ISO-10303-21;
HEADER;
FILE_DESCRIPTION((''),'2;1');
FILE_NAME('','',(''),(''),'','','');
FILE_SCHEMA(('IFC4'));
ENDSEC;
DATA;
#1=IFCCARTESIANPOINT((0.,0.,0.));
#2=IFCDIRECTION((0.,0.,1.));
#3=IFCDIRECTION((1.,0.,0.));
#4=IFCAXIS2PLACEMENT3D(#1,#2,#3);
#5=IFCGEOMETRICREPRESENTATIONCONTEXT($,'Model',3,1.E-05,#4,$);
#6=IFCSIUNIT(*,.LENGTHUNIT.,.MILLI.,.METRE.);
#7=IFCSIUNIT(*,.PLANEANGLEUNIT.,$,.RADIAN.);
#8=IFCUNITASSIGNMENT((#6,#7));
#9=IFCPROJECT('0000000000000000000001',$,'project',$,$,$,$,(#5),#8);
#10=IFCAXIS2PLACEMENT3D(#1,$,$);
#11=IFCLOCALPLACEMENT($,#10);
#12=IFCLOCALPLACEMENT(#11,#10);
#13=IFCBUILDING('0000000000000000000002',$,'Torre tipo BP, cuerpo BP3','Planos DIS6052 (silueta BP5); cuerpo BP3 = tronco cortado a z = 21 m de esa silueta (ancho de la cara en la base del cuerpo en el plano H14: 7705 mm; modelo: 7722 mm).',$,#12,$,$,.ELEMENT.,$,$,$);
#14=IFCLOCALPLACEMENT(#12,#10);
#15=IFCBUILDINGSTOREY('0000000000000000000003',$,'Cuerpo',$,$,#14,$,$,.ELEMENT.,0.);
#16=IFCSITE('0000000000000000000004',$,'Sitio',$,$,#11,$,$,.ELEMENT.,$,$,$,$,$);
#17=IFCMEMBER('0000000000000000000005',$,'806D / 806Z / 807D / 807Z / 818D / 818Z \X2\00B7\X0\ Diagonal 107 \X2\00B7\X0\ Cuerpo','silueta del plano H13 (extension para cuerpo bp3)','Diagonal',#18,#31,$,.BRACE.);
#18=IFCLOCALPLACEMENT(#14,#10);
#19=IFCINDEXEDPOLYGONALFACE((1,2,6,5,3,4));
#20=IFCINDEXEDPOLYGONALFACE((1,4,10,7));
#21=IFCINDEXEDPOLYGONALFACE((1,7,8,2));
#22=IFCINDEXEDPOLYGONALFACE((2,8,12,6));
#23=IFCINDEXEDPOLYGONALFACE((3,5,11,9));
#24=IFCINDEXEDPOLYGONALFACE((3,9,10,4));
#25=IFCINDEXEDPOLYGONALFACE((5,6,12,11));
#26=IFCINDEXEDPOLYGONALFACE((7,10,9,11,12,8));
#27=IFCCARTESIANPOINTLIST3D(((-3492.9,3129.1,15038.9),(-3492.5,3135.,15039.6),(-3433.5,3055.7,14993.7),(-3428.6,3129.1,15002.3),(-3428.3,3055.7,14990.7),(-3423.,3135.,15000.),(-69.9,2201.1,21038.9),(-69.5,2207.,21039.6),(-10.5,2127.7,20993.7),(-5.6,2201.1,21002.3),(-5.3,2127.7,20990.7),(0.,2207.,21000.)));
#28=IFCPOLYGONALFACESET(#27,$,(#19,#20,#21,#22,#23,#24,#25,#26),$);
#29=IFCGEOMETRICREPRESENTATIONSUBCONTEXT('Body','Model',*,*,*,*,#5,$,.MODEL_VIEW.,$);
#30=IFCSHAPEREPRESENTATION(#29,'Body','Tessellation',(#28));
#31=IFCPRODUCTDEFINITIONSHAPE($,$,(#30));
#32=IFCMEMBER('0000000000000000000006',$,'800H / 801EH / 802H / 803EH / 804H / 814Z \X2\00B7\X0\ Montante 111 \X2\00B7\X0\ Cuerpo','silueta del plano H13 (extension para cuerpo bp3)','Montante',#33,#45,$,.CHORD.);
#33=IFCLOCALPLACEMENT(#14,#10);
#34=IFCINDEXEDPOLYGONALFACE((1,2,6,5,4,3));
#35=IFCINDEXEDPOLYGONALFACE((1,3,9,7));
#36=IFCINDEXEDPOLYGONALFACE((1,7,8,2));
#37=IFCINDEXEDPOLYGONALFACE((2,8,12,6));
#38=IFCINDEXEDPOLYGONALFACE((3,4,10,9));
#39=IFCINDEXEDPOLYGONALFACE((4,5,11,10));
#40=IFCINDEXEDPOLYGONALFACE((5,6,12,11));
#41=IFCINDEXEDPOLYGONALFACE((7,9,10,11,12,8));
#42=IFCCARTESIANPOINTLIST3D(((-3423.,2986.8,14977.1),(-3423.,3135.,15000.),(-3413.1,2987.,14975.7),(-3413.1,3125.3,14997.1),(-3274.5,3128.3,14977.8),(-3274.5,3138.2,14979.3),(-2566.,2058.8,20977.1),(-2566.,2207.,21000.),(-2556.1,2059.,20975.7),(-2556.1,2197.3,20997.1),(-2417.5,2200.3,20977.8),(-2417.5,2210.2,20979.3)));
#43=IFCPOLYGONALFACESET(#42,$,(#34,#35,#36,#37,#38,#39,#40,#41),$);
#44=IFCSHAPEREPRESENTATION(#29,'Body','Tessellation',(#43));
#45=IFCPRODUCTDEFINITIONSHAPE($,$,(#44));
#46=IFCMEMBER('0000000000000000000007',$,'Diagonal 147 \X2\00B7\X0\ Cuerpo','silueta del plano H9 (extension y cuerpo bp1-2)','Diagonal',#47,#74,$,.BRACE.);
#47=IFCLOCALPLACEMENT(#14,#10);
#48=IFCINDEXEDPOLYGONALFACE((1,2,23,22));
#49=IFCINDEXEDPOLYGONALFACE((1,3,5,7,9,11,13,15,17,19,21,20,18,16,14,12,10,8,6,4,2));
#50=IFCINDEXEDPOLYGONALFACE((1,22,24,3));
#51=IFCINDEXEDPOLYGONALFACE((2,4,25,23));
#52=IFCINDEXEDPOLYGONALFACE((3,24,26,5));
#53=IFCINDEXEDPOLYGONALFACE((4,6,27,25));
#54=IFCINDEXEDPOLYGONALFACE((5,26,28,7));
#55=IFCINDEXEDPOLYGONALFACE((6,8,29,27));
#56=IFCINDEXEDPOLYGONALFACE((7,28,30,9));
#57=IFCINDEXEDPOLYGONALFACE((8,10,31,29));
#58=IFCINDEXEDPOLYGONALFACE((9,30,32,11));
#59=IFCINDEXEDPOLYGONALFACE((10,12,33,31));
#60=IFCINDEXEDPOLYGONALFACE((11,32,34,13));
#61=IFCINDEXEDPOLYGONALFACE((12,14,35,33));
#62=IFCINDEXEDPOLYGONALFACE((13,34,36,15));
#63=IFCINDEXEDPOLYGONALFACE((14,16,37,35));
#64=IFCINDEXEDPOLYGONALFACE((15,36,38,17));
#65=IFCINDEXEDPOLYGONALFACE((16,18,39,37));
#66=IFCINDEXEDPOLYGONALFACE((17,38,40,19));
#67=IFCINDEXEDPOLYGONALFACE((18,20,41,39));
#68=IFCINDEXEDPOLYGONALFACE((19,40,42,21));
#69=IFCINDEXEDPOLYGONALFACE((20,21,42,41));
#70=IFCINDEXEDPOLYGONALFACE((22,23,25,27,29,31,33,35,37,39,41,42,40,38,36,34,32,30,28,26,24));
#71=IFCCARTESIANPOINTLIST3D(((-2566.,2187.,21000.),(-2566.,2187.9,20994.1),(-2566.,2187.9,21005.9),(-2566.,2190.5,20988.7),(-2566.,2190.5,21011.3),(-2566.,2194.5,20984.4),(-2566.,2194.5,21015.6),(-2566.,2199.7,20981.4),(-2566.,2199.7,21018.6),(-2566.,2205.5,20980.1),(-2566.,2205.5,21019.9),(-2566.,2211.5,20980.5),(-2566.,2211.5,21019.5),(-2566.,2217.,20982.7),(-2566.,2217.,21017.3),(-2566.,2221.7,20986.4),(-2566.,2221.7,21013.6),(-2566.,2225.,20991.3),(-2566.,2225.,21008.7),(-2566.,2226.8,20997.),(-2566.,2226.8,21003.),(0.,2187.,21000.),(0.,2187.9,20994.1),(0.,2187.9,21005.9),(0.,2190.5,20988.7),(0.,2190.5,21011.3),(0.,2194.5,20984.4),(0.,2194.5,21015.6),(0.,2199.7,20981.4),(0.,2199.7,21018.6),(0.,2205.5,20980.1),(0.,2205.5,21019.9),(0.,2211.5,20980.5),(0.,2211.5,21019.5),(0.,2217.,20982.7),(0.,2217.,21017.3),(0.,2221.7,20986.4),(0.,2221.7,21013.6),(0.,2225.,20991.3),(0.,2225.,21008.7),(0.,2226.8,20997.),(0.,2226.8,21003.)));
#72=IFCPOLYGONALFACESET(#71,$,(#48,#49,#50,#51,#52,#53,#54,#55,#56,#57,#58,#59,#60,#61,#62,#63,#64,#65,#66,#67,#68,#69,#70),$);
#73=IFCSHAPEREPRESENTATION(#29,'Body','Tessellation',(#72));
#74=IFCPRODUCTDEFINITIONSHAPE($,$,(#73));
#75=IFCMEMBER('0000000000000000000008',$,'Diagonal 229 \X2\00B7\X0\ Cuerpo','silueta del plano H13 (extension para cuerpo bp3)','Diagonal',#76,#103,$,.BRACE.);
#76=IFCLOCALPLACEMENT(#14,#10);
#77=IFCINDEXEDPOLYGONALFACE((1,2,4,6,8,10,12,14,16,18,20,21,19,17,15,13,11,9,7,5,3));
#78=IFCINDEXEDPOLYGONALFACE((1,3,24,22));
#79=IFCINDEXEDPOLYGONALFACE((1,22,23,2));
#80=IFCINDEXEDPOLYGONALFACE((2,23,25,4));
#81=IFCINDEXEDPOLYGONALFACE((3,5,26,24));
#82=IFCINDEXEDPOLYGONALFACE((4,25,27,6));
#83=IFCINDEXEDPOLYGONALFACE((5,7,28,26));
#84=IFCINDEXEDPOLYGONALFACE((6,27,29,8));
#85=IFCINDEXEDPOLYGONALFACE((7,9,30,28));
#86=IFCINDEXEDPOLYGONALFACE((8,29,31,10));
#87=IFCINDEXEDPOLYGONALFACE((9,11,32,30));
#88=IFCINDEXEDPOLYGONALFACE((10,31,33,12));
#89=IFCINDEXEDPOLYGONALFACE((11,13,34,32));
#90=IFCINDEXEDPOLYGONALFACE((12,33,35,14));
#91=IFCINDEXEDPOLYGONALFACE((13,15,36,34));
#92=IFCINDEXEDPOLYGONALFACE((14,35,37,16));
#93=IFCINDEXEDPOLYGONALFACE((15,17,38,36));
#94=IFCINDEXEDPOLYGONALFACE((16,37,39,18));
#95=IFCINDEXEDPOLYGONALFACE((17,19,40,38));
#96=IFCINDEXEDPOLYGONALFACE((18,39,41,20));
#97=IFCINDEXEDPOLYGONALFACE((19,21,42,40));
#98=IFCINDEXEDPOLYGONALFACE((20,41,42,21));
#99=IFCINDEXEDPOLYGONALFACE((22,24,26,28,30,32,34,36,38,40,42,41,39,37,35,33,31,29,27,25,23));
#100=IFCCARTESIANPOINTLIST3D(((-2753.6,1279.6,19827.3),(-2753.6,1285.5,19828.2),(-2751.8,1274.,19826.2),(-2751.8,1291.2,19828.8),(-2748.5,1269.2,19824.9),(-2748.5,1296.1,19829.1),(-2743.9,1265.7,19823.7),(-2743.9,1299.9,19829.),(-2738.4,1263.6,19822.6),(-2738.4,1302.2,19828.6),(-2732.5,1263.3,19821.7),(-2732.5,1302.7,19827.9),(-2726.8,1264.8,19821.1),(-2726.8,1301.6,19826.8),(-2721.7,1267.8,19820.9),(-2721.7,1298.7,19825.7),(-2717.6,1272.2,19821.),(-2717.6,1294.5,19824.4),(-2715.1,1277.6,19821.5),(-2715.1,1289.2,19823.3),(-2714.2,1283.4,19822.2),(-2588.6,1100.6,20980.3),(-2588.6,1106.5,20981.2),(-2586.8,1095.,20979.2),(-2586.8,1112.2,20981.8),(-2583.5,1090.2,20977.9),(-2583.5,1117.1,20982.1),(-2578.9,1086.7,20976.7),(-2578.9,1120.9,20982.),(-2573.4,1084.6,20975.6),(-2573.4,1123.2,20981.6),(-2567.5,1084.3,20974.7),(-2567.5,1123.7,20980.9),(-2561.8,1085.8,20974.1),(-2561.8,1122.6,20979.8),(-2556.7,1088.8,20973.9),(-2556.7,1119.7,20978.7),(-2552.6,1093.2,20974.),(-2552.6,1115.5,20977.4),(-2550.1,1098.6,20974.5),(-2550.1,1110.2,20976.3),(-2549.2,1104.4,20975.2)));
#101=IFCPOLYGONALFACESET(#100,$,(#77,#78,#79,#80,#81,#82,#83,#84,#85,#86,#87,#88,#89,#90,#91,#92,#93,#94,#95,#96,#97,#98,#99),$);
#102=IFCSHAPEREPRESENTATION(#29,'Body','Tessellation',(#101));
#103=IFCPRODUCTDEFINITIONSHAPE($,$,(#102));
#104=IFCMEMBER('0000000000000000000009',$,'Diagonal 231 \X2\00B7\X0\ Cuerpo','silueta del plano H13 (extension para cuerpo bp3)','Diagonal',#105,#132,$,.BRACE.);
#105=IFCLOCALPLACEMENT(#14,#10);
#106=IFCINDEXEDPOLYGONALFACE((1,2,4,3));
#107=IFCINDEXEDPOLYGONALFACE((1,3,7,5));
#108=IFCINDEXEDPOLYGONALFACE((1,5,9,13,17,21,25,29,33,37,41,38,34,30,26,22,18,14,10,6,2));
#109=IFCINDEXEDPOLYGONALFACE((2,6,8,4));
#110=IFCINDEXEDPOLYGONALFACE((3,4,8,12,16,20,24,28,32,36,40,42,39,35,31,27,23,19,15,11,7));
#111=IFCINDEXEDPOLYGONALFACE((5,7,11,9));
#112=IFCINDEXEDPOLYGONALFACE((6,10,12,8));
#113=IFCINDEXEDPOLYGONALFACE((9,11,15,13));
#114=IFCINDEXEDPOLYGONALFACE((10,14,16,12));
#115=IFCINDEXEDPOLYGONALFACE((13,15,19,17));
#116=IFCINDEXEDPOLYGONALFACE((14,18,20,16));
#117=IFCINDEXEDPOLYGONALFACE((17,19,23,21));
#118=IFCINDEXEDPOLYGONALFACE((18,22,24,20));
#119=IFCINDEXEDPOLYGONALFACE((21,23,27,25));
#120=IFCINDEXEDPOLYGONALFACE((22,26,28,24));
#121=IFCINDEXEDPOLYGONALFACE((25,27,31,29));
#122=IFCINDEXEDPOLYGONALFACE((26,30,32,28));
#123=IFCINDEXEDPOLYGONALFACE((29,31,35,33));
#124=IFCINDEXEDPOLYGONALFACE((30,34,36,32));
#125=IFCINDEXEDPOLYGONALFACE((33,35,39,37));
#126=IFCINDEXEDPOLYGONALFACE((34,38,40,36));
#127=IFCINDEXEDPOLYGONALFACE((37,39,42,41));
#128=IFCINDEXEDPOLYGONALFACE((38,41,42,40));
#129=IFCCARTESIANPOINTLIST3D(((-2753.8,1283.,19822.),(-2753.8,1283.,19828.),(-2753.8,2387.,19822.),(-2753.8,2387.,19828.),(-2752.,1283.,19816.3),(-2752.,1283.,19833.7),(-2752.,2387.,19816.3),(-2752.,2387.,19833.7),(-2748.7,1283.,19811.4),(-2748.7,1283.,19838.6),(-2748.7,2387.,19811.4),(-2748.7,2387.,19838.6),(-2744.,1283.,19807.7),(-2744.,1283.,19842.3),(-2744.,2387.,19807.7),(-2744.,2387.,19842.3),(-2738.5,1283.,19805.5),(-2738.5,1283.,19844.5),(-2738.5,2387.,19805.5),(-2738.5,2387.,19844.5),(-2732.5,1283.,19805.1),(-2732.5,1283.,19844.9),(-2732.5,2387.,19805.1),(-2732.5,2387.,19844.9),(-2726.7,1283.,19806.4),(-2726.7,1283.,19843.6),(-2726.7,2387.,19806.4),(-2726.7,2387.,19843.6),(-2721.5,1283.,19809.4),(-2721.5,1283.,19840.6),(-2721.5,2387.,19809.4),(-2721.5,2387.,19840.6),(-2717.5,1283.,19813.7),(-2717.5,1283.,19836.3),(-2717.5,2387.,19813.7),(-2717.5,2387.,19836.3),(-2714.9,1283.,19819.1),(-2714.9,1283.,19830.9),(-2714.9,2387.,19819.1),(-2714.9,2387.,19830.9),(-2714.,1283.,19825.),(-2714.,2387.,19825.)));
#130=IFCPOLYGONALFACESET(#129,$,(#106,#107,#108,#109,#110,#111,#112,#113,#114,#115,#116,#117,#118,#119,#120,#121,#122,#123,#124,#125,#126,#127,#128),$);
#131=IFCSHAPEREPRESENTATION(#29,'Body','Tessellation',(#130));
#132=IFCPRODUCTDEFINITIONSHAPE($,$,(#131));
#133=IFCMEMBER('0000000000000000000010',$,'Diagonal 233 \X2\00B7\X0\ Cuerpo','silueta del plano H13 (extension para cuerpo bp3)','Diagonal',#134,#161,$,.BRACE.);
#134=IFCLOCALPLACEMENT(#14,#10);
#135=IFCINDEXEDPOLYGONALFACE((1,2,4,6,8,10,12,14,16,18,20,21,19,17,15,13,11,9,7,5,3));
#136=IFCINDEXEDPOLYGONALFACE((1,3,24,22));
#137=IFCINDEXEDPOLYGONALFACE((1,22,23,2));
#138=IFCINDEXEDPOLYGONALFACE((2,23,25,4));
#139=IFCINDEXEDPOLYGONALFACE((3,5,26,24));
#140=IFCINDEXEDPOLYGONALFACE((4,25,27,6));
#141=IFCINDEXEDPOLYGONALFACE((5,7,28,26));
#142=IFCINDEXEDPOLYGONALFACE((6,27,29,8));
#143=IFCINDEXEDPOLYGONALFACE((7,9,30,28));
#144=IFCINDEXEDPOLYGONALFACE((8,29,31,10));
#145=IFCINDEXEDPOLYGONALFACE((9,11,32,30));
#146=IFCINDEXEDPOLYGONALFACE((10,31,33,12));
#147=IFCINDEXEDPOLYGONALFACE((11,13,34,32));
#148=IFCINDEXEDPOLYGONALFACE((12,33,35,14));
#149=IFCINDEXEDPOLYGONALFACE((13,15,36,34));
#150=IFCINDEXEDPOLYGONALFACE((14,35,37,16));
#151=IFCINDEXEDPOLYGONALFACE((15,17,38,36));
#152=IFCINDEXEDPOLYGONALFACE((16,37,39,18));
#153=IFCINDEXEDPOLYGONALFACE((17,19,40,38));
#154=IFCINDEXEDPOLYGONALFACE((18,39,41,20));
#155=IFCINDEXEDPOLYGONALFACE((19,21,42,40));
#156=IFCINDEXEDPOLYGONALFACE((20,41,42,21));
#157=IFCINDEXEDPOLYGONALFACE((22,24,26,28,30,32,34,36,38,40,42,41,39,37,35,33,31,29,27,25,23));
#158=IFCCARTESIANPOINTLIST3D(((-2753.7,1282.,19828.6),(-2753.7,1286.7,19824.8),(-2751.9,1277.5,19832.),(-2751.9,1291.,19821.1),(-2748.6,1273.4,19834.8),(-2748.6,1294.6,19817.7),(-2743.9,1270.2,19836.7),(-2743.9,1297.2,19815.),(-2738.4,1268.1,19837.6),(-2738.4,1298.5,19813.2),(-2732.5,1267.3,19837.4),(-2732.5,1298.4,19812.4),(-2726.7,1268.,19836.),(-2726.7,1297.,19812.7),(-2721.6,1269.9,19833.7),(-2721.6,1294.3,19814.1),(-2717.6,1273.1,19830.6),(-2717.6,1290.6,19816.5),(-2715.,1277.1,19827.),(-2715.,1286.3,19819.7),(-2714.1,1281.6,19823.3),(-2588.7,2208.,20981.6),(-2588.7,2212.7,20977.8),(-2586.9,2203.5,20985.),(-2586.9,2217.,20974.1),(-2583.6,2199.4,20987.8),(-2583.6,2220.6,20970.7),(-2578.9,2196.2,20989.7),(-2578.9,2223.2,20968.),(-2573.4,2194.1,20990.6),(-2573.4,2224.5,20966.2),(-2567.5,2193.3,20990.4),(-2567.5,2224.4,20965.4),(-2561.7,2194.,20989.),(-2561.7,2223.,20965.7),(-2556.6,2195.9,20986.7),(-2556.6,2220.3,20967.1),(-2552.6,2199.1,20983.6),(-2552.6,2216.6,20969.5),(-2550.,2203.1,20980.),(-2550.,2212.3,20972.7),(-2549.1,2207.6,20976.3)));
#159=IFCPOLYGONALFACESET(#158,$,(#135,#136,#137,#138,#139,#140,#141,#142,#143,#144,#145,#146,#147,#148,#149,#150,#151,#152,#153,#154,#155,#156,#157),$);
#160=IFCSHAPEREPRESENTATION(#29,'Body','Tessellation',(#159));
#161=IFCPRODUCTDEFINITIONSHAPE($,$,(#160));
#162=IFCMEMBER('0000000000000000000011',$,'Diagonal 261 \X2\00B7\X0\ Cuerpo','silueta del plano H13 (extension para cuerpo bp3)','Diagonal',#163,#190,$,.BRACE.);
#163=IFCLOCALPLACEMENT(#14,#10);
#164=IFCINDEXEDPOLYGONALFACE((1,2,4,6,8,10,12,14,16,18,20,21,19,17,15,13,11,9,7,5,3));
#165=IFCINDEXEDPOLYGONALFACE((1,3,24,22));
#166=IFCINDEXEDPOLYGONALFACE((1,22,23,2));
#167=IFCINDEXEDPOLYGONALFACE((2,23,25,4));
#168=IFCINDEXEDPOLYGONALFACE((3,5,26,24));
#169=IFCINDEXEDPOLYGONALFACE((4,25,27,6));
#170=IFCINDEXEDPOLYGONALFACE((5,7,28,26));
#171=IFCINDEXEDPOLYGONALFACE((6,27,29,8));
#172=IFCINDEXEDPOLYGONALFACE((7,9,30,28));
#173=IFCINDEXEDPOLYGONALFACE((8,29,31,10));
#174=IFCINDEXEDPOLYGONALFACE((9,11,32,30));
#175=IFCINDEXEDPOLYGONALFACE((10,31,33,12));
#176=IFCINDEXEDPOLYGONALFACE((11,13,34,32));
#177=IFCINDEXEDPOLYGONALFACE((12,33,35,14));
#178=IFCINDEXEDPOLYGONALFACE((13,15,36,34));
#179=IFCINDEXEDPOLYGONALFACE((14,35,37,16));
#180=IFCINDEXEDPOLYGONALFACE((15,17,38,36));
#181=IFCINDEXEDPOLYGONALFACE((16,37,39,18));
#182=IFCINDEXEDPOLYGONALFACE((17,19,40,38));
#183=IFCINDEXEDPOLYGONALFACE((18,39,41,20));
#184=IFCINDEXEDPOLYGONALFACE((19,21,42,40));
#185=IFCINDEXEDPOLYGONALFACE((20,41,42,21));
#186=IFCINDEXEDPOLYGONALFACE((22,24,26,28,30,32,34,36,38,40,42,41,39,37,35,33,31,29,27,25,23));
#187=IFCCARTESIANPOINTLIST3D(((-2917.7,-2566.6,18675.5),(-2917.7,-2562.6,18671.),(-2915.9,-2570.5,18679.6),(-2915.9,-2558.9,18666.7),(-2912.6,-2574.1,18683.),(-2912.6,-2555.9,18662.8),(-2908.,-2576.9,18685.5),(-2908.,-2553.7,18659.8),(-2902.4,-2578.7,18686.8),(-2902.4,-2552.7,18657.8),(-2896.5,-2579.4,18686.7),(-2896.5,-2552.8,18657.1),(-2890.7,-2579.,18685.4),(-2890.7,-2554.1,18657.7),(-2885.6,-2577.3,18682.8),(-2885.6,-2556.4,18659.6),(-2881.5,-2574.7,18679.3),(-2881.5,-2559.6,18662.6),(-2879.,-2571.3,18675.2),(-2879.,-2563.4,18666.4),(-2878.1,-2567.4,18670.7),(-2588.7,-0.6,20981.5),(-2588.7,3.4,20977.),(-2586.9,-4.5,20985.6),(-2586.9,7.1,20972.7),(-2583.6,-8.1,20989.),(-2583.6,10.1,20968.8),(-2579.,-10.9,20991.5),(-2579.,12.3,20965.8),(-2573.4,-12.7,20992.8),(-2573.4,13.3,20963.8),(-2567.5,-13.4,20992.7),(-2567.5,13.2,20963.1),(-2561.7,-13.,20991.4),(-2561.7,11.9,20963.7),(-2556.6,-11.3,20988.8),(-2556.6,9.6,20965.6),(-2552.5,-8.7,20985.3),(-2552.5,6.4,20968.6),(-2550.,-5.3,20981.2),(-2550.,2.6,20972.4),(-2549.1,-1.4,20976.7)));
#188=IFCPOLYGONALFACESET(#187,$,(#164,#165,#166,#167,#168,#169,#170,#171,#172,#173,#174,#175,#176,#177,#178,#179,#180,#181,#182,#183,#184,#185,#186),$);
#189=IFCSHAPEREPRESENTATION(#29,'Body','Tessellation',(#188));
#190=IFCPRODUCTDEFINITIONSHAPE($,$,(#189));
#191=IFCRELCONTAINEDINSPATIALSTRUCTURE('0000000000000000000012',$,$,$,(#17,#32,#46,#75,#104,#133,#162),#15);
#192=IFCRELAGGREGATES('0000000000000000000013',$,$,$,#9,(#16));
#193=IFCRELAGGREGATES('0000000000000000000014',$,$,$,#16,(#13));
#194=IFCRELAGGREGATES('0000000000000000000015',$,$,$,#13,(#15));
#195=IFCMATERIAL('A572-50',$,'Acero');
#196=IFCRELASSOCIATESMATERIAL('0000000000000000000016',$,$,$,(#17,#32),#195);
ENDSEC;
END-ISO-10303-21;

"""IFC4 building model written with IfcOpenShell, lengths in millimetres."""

from ifc_helpers import new_model, si_unit, frame, frame_2d, origin, origin_with_axes, place, context, subcontext, project, spatial, circle, l_section, extrude, material, element, save


model = new_model("IFC4")

# Units and contexts
model_context = context("Model", 3, precision=1e-05, world=origin_with_axes())
body_context = subcontext(model_context, "Body", "Model", "MODEL_VIEW")
ifc_project = project(units=[si_unit("LENGTHUNIT", "METRE", prefix="MILLI"), si_unit("PLANEANGLEUNIT", "RADIAN")], contexts=[model_context])

# Site, building, storey
site_placement = place(None, origin())
site = spatial("IfcSite", under=ifc_project, at=site_placement, Name="Sitio", CompositionType="ELEMENT")
building_placement = place(site_placement, origin())
building = spatial("IfcBuilding", under=site, at=building_placement, Name="Torre tipo BP, cuerpo BP3", Description="Planos DIS6052 (silueta BP5); cuerpo BP3 = tronco cortado a z = 21 m de esa silueta (ancho de la cara en la base del cuerpo en el plano H14: 7705 mm; modelo: 7722 mm).", CompositionType="ELEMENT")
storey_placement = place(building_placement, origin())
storey = spatial("IfcBuildingStorey", under=building, at=storey_placement, Name="Cuerpo", CompositionType="ELEMENT", Elevation=0.0)

# Members
ifc_material_1 = material(Name="A572-50", Category="Acero")
member_1_placement = place(storey_placement, frame((0.0, 2207.0, 21000.0), z_axis=(-0.491119, 0.133146, -0.860857), x_axis=(-0.065978, -0.991096, -0.115649)))
element("IfcMember", 1, at=member_1_placement, inside=storey, material=ifc_material_1, Name="806D / 806Z / 807D / 807Z / 818D / 818Z · Diagonal 107 · Cuerpo", Description="silueta del plano H13 (extension para cuerpo bp3)", ObjectType="Diagonal", PredefinedType="BRACE", context=body_context, shape_type="SweptSolid", body=[
    extrude(l_section(Depth=80.0, Width=80.0, Thickness=6.0, at=frame_2d((40.0, 40.0))), None, (0.0, 0.0, 1.0), 6969.8),
])
member_2_placement = place(storey_placement, frame((-2566.0, 2207.0, 21000.0), z_axis=(-0.139769, 0.151349, -0.978549), x_axis=(0.990184, 0.021364, -0.138127)))
element("IfcMember", 2, at=member_2_placement, inside=storey, material=ifc_material_1, Name="800H / 801EH / 802H / 803EH / 804H / 814Z · Montante 111 · Cuerpo", Description="silueta del plano H13 (extension para cuerpo bp3)", ObjectType="Montante", PredefinedType="CHORD", context=body_context, shape_type="SweptSolid", body=[
    extrude(l_section(Depth=150.0, Width=150.0, Thickness=10.0, at=frame_2d((75.0, 75.0))), None, (0.0, 0.0, 1.0), 6131.5),
])
member_3_placement = place(storey_placement, frame((-2566.0, 2207.0, 21000.0), z_axis=(1.0, 0.0, 0.0), x_axis=(0.0, -1.0, 0.0)))
element("IfcMember", 3, at=member_3_placement, inside=storey, Name="Diagonal 147 · Cuerpo", Description="silueta del plano H9 (extension y cuerpo bp1-2)", ObjectType="Diagonal", PredefinedType="BRACE", context=body_context, shape_type="SweptSolid", body=[
    extrude(circle(Radius=20.0), None, (0.0, 0.0, 1.0), 2566.0),
])
member_4_placement = place(storey_placement, frame((-2569.0, 1104.0, 20978.0), z_axis=(-0.140018, 0.151898, -0.978428), x_axis=(0.990149, 0.02148, -0.13836)))
element("IfcMember", 4, at=member_4_placement, inside=storey, Name="Diagonal 229 · Cuerpo", Description="silueta del plano H13 (extension para cuerpo bp3)", ObjectType="Diagonal", PredefinedType="BRACE", context=body_context, shape_type="SweptSolid", body=[
    extrude(circle(Radius=20.0), None, (0.0, 0.0, 1.0), 1178.4),
])
member_5_placement = place(storey_placement, frame((-2734.0, 1283.0, 19825.0), z_axis=(0.0, 1.0, 0.0), x_axis=(1.0, 0.0, 0.0)))
element("IfcMember", 5, at=member_5_placement, inside=storey, Name="Diagonal 231 · Cuerpo", Description="silueta del plano H13 (extension para cuerpo bp3)", ObjectType="Diagonal", PredefinedType="BRACE", context=body_context, shape_type="SweptSolid", body=[
    extrude(circle(Radius=20.0), None, (0.0, 0.0, 1.0), 1104.0),
])
member_6_placement = place(storey_placement, frame((-2734.0, 1283.0, 19825.0), z_axis=(0.110888, 0.622317, 0.774872), x_axis=(0.993833, -0.069436, -0.086457)))
element("IfcMember", 6, at=member_6_placement, inside=storey, Name="Diagonal 233 · Cuerpo", Description="silueta del plano H13 (extension para cuerpo bp3)", ObjectType="Diagonal", PredefinedType="BRACE", context=body_context, shape_type="SweptSolid", body=[
    extrude(circle(Radius=20.0), None, (0.0, 0.0, 1.0), 1488.0),
])
for number, where, z_axis, x_axis, name in (
    (7, (-2569.0, 0.0, 20978.0), (-0.094934, -0.740425, -0.665401), (0.995484, -0.07061, -0.063456), "Diagonal 261 · Cuerpo"),
):
    element("IfcMember", number, at=place(storey_placement, frame(where, z_axis=z_axis, x_axis=x_axis)), inside=storey, Name=name, Description="silueta del plano H13 (extension para cuerpo bp3)", ObjectType="Diagonal", PredefinedType="BRACE", context=body_context, shape_type="SweptSolid", body=[
        extrude(circle(Radius=20.0), None, (0.0, 0.0, 1.0), 3465.6),
    ])

save(model, "model.ifc")
